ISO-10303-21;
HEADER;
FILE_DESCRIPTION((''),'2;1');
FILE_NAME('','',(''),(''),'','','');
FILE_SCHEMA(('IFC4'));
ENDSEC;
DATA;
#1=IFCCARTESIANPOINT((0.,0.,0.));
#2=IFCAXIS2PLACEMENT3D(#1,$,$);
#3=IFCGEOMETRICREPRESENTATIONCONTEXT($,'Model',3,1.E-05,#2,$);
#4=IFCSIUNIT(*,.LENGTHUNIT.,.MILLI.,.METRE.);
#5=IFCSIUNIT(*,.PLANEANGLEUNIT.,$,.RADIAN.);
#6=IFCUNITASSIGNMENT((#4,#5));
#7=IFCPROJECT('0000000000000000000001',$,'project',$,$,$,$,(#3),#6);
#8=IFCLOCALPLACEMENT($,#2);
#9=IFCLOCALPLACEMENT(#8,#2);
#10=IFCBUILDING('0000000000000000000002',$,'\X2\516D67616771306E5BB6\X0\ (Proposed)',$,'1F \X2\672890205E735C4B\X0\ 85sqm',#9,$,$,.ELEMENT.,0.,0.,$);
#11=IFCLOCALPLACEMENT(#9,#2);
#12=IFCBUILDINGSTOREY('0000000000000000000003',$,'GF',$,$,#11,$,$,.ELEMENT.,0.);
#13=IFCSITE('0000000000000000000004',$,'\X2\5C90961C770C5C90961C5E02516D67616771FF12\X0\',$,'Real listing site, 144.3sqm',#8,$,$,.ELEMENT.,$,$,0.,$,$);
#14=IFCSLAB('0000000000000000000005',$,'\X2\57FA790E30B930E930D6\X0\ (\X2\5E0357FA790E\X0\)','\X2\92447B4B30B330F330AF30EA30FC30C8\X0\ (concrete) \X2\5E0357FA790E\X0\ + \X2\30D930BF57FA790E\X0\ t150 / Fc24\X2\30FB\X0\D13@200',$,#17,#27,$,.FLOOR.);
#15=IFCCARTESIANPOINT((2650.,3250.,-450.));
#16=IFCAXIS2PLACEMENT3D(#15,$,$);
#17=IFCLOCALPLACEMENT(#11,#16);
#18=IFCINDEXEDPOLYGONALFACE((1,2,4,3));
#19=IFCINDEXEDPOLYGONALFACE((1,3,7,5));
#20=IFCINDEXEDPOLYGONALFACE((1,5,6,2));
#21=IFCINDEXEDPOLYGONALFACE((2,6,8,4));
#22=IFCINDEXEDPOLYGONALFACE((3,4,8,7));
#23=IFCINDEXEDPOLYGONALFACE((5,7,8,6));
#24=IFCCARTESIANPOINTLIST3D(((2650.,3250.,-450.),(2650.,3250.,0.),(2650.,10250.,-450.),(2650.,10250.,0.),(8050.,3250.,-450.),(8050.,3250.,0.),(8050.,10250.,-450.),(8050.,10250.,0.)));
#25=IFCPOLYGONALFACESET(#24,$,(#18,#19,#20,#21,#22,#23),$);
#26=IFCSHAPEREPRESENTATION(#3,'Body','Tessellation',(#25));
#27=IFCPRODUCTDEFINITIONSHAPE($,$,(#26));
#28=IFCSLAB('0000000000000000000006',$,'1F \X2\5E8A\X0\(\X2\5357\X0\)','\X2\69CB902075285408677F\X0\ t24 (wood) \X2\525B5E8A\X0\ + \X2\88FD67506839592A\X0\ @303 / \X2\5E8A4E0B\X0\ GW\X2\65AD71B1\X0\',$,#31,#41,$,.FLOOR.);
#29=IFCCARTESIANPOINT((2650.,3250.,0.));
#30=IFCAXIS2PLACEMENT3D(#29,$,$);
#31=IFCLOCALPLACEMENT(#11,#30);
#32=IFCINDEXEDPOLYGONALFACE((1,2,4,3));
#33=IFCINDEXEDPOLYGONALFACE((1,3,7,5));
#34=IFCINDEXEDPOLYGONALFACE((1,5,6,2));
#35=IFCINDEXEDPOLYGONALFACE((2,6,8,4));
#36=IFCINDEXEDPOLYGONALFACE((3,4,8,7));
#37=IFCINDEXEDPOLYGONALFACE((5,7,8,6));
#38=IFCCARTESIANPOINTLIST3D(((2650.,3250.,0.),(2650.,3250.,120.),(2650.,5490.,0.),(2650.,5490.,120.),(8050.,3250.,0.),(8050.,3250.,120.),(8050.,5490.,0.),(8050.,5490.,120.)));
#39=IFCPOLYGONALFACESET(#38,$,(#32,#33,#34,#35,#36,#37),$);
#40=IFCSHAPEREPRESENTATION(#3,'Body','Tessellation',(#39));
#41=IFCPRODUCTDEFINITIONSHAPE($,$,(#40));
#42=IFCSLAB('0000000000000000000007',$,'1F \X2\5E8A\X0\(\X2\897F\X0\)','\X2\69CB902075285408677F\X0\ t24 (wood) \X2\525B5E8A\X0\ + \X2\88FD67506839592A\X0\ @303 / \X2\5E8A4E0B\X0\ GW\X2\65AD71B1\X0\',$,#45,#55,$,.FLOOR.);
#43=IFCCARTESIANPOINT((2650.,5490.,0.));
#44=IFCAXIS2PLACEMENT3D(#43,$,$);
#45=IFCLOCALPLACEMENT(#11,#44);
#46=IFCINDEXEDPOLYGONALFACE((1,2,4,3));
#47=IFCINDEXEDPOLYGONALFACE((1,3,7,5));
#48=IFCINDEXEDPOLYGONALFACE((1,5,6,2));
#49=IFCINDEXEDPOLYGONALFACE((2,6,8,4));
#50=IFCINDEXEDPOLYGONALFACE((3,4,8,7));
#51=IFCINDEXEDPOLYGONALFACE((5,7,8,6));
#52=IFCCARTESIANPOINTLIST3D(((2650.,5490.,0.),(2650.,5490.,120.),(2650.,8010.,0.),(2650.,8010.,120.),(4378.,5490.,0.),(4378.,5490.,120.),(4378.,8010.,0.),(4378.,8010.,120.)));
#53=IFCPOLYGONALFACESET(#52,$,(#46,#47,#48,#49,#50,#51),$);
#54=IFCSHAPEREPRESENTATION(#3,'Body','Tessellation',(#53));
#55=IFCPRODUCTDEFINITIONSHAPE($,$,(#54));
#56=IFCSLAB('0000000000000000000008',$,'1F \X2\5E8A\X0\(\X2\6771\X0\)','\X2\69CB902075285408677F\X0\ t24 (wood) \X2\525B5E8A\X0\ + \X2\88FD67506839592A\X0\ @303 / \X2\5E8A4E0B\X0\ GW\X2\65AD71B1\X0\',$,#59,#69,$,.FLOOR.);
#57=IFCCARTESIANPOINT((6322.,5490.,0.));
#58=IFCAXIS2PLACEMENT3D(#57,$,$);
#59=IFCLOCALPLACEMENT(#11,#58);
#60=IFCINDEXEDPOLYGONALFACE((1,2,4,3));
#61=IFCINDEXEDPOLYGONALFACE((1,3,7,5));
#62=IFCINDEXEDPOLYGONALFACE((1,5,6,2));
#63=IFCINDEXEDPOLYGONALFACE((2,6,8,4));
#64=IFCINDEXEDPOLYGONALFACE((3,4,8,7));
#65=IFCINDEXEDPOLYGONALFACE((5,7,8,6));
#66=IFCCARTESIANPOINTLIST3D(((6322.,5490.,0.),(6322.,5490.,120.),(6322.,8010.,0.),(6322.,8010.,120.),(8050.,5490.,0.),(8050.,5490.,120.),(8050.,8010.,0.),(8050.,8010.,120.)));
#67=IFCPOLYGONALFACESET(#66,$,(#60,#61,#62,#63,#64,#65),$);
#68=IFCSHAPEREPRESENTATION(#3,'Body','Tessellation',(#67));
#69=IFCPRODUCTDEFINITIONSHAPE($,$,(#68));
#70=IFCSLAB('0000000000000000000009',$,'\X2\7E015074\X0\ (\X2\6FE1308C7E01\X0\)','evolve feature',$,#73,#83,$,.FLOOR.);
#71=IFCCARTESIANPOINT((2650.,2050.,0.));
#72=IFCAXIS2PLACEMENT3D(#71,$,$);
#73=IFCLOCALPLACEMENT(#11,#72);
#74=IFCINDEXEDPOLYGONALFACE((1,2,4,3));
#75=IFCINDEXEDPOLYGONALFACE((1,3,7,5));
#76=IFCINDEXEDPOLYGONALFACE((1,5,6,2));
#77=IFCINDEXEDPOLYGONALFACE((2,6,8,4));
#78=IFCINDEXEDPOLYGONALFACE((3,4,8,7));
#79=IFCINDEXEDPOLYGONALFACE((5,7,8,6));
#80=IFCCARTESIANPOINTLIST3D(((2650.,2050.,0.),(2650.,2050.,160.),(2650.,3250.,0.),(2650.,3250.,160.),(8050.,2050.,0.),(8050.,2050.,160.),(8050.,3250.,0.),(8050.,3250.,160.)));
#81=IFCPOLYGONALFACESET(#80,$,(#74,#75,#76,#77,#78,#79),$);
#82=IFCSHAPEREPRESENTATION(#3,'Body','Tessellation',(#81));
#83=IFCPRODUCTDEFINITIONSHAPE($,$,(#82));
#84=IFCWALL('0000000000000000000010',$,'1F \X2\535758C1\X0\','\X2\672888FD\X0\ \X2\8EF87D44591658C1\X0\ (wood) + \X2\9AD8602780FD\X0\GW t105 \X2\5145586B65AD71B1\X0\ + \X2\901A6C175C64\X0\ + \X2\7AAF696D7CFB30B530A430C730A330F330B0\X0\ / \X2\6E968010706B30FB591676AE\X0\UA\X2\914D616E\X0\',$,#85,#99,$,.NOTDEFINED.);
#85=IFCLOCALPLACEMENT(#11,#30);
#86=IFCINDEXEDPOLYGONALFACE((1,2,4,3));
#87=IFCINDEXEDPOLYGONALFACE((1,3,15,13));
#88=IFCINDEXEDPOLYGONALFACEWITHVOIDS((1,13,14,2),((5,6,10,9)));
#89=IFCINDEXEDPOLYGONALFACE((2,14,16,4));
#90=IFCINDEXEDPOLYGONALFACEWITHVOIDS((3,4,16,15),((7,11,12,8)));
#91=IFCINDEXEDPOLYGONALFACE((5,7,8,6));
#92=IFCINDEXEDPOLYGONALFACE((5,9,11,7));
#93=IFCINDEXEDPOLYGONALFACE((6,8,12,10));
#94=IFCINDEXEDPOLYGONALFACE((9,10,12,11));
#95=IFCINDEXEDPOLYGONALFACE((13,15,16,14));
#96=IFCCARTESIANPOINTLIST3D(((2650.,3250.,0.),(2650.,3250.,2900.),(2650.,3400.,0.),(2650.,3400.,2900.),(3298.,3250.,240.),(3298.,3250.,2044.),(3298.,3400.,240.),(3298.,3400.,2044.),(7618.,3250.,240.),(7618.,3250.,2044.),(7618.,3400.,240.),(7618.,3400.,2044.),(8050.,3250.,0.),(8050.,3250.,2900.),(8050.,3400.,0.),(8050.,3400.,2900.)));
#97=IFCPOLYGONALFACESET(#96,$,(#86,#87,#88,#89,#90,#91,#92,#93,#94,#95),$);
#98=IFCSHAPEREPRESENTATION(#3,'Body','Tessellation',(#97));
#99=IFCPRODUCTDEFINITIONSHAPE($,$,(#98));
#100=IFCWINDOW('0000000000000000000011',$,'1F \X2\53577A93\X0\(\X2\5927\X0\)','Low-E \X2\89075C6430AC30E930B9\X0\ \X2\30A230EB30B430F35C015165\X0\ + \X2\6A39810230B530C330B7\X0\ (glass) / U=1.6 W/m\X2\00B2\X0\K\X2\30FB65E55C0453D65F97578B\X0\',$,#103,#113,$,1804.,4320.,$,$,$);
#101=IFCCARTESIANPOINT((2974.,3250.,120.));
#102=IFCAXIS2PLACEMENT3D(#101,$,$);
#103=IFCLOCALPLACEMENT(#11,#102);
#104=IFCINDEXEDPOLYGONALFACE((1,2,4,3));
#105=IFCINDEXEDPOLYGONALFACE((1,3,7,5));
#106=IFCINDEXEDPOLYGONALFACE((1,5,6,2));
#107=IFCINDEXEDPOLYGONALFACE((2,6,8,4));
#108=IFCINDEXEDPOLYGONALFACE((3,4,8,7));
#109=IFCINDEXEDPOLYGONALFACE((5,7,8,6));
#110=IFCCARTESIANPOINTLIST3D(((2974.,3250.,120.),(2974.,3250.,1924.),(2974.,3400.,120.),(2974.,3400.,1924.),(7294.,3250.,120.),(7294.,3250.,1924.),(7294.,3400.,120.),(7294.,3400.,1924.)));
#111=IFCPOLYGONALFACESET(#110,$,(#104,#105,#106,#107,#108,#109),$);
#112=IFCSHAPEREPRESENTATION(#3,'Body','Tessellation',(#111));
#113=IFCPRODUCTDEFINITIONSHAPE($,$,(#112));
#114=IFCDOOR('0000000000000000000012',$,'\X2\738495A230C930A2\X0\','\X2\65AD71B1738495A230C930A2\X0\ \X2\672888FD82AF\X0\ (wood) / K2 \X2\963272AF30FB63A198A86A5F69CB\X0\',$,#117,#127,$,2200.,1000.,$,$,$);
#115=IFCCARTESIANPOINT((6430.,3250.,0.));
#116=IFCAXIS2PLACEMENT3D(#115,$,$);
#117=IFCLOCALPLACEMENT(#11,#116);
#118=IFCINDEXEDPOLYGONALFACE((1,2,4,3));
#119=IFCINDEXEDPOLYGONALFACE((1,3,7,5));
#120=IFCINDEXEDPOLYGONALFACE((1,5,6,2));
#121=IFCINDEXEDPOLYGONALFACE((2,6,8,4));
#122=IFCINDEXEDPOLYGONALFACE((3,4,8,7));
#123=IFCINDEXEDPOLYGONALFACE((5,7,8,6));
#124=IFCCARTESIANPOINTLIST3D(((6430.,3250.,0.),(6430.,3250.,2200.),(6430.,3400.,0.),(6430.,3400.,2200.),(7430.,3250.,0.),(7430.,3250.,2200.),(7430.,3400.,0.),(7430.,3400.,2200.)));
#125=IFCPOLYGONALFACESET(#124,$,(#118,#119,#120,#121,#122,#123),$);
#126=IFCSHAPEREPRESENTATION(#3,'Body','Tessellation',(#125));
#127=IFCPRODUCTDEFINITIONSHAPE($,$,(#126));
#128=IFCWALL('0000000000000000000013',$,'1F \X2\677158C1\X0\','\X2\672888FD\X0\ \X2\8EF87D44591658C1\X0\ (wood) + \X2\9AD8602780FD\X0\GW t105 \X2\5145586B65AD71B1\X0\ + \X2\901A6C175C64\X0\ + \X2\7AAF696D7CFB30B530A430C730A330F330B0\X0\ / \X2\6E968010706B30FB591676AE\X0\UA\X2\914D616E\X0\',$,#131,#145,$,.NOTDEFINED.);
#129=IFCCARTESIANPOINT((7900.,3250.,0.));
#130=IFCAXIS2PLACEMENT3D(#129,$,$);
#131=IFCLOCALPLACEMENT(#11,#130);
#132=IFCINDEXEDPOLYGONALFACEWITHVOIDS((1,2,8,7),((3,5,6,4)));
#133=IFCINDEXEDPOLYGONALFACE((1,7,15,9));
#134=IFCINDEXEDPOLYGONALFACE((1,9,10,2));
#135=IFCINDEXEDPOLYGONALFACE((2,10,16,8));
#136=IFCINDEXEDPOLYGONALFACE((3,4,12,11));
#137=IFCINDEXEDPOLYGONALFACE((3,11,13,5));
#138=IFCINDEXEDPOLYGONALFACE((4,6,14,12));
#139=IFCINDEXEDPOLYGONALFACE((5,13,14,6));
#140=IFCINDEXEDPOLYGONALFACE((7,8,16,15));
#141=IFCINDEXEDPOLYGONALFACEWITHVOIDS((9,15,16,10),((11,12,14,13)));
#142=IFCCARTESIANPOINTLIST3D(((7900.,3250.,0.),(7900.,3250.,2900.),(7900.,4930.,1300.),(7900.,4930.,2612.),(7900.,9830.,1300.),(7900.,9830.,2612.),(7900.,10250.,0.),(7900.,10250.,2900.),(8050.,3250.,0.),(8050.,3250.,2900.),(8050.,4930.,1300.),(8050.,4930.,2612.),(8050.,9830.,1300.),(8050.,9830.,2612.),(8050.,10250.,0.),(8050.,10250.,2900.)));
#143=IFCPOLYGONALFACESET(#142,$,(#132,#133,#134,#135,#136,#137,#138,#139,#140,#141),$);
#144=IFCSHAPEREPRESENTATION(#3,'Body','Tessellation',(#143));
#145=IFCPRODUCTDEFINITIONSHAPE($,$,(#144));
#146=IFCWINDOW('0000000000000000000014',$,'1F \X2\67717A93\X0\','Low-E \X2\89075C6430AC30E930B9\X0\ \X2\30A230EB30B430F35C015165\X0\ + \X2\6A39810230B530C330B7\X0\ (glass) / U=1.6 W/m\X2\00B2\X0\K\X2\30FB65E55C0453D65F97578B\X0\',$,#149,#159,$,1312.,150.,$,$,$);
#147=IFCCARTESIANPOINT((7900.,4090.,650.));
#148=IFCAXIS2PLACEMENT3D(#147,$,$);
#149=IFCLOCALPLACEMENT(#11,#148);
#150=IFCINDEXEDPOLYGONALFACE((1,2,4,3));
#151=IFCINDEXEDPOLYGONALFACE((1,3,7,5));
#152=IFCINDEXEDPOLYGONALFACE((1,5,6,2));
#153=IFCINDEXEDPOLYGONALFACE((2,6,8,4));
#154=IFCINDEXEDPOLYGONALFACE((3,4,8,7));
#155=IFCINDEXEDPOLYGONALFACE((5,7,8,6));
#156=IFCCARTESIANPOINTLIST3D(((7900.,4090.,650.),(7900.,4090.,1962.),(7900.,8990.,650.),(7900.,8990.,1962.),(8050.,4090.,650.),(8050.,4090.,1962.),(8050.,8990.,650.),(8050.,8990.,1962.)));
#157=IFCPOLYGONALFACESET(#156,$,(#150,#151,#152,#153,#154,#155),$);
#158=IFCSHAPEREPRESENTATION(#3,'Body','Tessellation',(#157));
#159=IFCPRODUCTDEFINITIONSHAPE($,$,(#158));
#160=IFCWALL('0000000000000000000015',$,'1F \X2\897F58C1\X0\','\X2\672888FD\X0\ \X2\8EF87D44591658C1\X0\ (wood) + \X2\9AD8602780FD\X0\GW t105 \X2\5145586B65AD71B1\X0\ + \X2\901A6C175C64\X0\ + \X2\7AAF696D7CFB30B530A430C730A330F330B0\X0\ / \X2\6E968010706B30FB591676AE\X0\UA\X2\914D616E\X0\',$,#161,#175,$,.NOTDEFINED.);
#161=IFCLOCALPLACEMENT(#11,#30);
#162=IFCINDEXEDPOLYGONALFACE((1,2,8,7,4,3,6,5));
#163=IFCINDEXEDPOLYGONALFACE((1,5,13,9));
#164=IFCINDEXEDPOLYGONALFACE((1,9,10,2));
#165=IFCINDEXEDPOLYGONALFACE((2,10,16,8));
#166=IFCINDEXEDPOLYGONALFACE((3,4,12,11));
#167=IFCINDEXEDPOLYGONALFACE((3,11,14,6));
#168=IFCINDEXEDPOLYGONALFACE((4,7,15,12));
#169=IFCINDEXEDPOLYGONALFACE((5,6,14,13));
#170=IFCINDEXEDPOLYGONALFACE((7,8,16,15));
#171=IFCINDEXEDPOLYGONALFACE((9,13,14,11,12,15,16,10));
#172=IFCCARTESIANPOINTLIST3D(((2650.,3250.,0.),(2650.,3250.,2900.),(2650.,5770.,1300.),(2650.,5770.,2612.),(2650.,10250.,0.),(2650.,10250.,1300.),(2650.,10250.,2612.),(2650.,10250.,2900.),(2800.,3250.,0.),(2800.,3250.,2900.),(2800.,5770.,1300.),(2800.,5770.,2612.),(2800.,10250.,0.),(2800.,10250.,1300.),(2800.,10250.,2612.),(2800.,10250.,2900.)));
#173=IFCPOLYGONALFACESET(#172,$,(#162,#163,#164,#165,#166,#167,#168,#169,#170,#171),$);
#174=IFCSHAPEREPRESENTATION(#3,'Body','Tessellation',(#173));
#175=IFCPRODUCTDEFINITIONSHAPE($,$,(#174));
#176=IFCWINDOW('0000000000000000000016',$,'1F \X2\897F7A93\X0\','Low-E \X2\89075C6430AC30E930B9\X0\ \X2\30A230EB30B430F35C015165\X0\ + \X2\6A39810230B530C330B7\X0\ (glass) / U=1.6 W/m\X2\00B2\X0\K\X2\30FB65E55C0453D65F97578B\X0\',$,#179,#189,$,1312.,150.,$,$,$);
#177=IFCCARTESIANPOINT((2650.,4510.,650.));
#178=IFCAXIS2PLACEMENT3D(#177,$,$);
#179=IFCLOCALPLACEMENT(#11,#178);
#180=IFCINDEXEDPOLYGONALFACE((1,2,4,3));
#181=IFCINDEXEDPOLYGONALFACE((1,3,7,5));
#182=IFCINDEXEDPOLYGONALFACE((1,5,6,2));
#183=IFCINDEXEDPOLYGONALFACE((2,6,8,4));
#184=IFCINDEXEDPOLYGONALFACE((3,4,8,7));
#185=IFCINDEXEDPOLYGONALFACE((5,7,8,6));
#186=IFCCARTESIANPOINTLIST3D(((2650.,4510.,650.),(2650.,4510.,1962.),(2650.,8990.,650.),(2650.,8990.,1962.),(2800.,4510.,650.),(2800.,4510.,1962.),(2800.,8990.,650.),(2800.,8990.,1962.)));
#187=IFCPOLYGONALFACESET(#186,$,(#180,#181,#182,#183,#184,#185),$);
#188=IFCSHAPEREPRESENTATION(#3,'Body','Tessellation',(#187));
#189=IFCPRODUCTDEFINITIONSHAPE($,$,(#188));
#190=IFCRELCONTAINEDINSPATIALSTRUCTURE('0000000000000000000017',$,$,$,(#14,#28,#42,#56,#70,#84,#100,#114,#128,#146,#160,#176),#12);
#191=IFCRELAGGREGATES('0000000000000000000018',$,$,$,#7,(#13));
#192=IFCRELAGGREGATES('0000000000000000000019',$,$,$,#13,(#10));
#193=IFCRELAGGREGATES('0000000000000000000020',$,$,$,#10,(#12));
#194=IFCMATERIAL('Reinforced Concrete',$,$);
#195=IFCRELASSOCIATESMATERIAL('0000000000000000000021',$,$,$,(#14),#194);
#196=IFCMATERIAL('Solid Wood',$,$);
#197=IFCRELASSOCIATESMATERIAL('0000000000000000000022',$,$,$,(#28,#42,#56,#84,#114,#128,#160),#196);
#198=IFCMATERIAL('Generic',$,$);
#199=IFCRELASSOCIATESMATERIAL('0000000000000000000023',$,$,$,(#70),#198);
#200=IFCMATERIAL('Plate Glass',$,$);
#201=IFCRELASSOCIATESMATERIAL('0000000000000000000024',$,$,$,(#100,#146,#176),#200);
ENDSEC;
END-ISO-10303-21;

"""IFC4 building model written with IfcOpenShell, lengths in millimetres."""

from ifc_helpers import new_model, si_unit, frame, frame_2d, origin, place, context, project, spatial, rectangle, extrude, material, element, fill, save


model = new_model("IFC4")

# Units and contexts
model_context = context("Model", 3, precision=1e-05, world=origin())
ifc_project = project(units=[si_unit("LENGTHUNIT", "METRE", prefix="MILLI"), si_unit("PLANEANGLEUNIT", "RADIAN")], contexts=[model_context])

# Site, building, storey
site_placement = place(None, origin())
site = spatial("IfcSite", under=ifc_project, at=site_placement, Name="岐阜県岐阜市六条東２", ObjectType="Real listing site, 144.3sqm", CompositionType="ELEMENT", RefElevation=0.0)
building_placement = place(site_placement, origin())
building = spatial("IfcBuilding", under=site, at=building_placement, Name="六条東の家 (Proposed)", ObjectType="1F 木造平屋 85sqm", CompositionType="ELEMENT", ElevationOfRefHeight=0.0, ElevationOfTerrain=0.0)
storey_placement = place(building_placement, origin())
storey = spatial("IfcBuildingStorey", under=building, at=storey_placement, Name="GF", CompositionType="ELEMENT", Elevation=0.0)

# Slabs
ifc_material_1 = material(Name="Reinforced Concrete")
slab_1_placement = place(storey_placement, frame((2650.0, 3250.0, -450.0)))
element("IfcSlab", 1, at=slab_1_placement, inside=storey, material=ifc_material_1, Name="基礎スラブ (布基礎)", Description="鉄筋コンクリート (concrete) 布基礎 + ベタ基礎 t150 / Fc24・D13@200", PredefinedType="FLOOR", context=model_context, shape_type="SweptSolid", body=[
    extrude(rectangle(XDim=5400.0, YDim=7000.0, at=frame_2d((2700.0, 3500.0))), frame((2650.0, 3250.0, -450.0)), (0.0, 0.0, 1.0), 450.0),
])
ifc_material_2 = material(Name="Solid Wood")
slab_2_placement = place(storey_placement, frame((2650.0, 3250.0, 0.0)))
element("IfcSlab", 2, at=slab_2_placement, inside=storey, material=ifc_material_2, Name="1F 床(南)", Description="構造用合板 t24 (wood) 剛床 + 製材根太 @303 / 床下 GW断熱", PredefinedType="FLOOR", context=model_context, shape_type="SweptSolid", body=[
    extrude(rectangle(XDim=5400.0, YDim=2240.0, at=frame_2d((2700.0, 1120.0))), frame((2650.0, 3250.0, 0.0)), (0.0, 0.0, 1.0), 120.0),
])
slab_3_placement = place(storey_placement, frame((2650.0, 5490.0, 0.0)))
element("IfcSlab", 3, at=slab_3_placement, inside=storey, material=ifc_material_2, Name="1F 床(西)", Description="構造用合板 t24 (wood) 剛床 + 製材根太 @303 / 床下 GW断熱", PredefinedType="FLOOR", context=model_context, shape_type="SweptSolid", body=[
    extrude(rectangle(XDim=1728.0, YDim=2520.0, at=frame_2d((864.0, 1260.0))), frame((2650.0, 5490.0, 0.0)), (0.0, 0.0, 1.0), 120.0),
])
slab_4_placement = place(storey_placement, frame((6322.0, 5490.0, 0.0)))
element("IfcSlab", 4, at=slab_4_placement, inside=storey, material=ifc_material_2, Name="1F 床(東)", Description="構造用合板 t24 (wood) 剛床 + 製材根太 @303 / 床下 GW断熱", PredefinedType="FLOOR", context=model_context, shape_type="SweptSolid", body=[
    extrude(rectangle(XDim=1728.0, YDim=2520.0, at=frame_2d((864.0, 1260.0))), frame((6322.0, 5490.0, 0.0)), (0.0, 0.0, 1.0), 120.0),
])
ifc_material_3 = material(Name="Generic")
slab_5_placement = place(storey_placement, frame((2650.0, 2050.0, 0.0)))
element("IfcSlab", 5, at=slab_5_placement, inside=storey, material=ifc_material_3, Name="縁側 (濡れ縁)", Description="evolve feature", PredefinedType="FLOOR", context=model_context, shape_type="SweptSolid", body=[
    extrude(rectangle(XDim=5400.0, YDim=1200.0, at=frame_2d((2700.0, 600.0))), frame((2650.0, 2050.0, 0.0)), (0.0, 0.0, 1.0), 160.0),
])

# Wall, openings, window, door
wall_1_placement = place(storey_placement, frame((2650.0, 3250.0, 0.0)))
wall_1 = element("IfcWall", 6, at=wall_1_placement, inside=storey, material=ifc_material_2, Name="1F 南壁", Description="木製 軸組外壁 (wood) + 高性能GW t105 充填断熱 + 通気層 + 窯業系サイディング / 準耐火・外皮UA配慮", PredefinedType="NOTDEFINED", context=model_context, shape_type="SweptSolid", body=[
    extrude(rectangle(XDim=5400.0, YDim=150.0, at=frame_2d((2700.0, 75.0))), frame((2650.0, 3250.0, 0.0)), (0.0, 0.0, 1.0), 2900.0),
])
opening_1_placement = place(storey_placement, frame((2974.0, 3250.0, 120.0)))
opening_1 = element("IfcOpeningElement", 7, at=opening_1_placement, cuts=wall_1, PredefinedType="NOTDEFINED", context=model_context, shape_type="SweptSolid", body=[
    extrude(rectangle(XDim=4320.0, YDim=150.0, at=frame_2d((2160.0, 75.0))), frame((2974.0, 3250.0, 120.0)), (0.0, 0.0, 1.0), 1804.0),
])
opening_2_placement = place(storey_placement, frame((6430.0, 3250.0, 0.0)))
opening_2 = element("IfcOpeningElement", 8, at=opening_2_placement, cuts=wall_1, PredefinedType="NOTDEFINED", context=model_context, shape_type="SweptSolid", body=[
    extrude(rectangle(XDim=1000.0, YDim=150.0, at=frame_2d((500.0, 75.0))), frame((6430.0, 3250.0, 0.0)), (0.0, 0.0, 1.0), 2200.0),
])
ifc_material_4 = material(Name="Plate Glass")
window_1_placement = place(storey_placement, frame((2974.0, 3250.0, 120.0)))
window_1 = element("IfcWindow", 9, at=window_1_placement, inside=storey, material=ifc_material_4, Name="1F 南窓(大)", Description="Low-E 複層ガラス アルゴン封入 + 樹脂サッシ (glass) / U=1.6 W/m²K・日射取得型", OverallHeight=1804.0, OverallWidth=4320.0, context=model_context, shape_type="SweptSolid", body=[
    extrude(rectangle(XDim=4320.0, YDim=150.0, at=frame_2d((2160.0, 75.0))), frame((2974.0, 3250.0, 120.0)), (0.0, 0.0, 1.0), 1804.0),
])
fill(opening_1, window_1)
door_placement = place(storey_placement, frame((6430.0, 3250.0, 0.0)))
door = element("IfcDoor", 10, at=door_placement, inside=storey, material=ifc_material_2, Name="玄関ドア", Description="断熱玄関ドア 木製芯 (wood) / K2 防犯・採風機構", OverallHeight=2200.0, OverallWidth=1000.0, context=model_context, shape_type="SweptSolid", body=[
    extrude(rectangle(XDim=1000.0, YDim=150.0, at=frame_2d((500.0, 75.0))), frame((6430.0, 3250.0, 0.0)), (0.0, 0.0, 1.0), 2200.0),
])
fill(opening_2, door)

# Walls, openings, windows
wall_2_placement = place(storey_placement, frame((7900.0, 3250.0, 0.0)))
wall_2 = element("IfcWall", 11, at=wall_2_placement, inside=storey, material=ifc_material_2, Name="1F 東壁", Description="木製 軸組外壁 (wood) + 高性能GW t105 充填断熱 + 通気層 + 窯業系サイディング / 準耐火・外皮UA配慮", PredefinedType="NOTDEFINED", context=model_context, shape_type="SweptSolid", body=[
    extrude(rectangle(XDim=150.0, YDim=7000.0, at=frame_2d((75.0, 3500.0))), frame((7900.0, 3250.0, 0.0)), (0.0, 0.0, 1.0), 2900.0),
])
opening_3_placement = place(storey_placement, frame((7900.0, 4090.0, 650.0)))
opening_3 = element("IfcOpeningElement", 12, at=opening_3_placement, cuts=wall_2, PredefinedType="NOTDEFINED", context=model_context, shape_type="SweptSolid", body=[
    extrude(rectangle(XDim=150.0, YDim=4900.0, at=frame_2d((75.0, 2450.0))), frame((7900.0, 4090.0, 650.0)), (0.0, 0.0, 1.0), 1312.0),
])
window_2_placement = place(storey_placement, frame((7900.0, 4090.0, 650.0)))
window_2 = element("IfcWindow", 13, at=window_2_placement, inside=storey, material=ifc_material_4, Name="1F 東窓", Description="Low-E 複層ガラス アルゴン封入 + 樹脂サッシ (glass) / U=1.6 W/m²K・日射取得型", OverallHeight=1312.0, OverallWidth=150.0, context=model_context, shape_type="SweptSolid", body=[
    extrude(rectangle(XDim=150.0, YDim=4900.0, at=frame_2d((75.0, 2450.0))), frame((7900.0, 4090.0, 650.0)), (0.0, 0.0, 1.0), 1312.0),
])
fill(opening_3, window_2)
wall_3_placement = place(storey_placement, frame((2650.0, 3250.0, 0.0)))
wall_3 = element("IfcWall", 14, at=wall_3_placement, inside=storey, material=ifc_material_2, Name="1F 西壁", Description="木製 軸組外壁 (wood) + 高性能GW t105 充填断熱 + 通気層 + 窯業系サイディング / 準耐火・外皮UA配慮", PredefinedType="NOTDEFINED", context=model_context, shape_type="SweptSolid", body=[
    extrude(rectangle(XDim=150.0, YDim=7000.0, at=frame_2d((75.0, 3500.0))), frame((2650.0, 3250.0, 0.0)), (0.0, 0.0, 1.0), 2900.0),
])
opening_4_placement = place(storey_placement, frame((2650.0, 4510.0, 650.0)))
opening_4 = element("IfcOpeningElement", 15, at=opening_4_placement, cuts=wall_3, PredefinedType="NOTDEFINED", context=model_context, shape_type="SweptSolid", body=[
    extrude(rectangle(XDim=150.0, YDim=4480.0, at=frame_2d((75.0, 2240.0))), frame((2650.0, 4510.0, 650.0)), (0.0, 0.0, 1.0), 1312.0),
])
window_3_placement = place(storey_placement, frame((2650.0, 4510.0, 650.0)))
window_3 = element("IfcWindow", 16, at=window_3_placement, inside=storey, material=ifc_material_4, Name="1F 西窓", Description="Low-E 複層ガラス アルゴン封入 + 樹脂サッシ (glass) / U=1.6 W/m²K・日射取得型", OverallHeight=1312.0, OverallWidth=150.0, context=model_context, shape_type="SweptSolid", body=[
    extrude(rectangle(XDim=150.0, YDim=4480.0, at=frame_2d((75.0, 2240.0))), frame((2650.0, 4510.0, 650.0)), (0.0, 0.0, 1.0), 1312.0),
])
fill(opening_4, window_3)

save(model, "model.ifc")
